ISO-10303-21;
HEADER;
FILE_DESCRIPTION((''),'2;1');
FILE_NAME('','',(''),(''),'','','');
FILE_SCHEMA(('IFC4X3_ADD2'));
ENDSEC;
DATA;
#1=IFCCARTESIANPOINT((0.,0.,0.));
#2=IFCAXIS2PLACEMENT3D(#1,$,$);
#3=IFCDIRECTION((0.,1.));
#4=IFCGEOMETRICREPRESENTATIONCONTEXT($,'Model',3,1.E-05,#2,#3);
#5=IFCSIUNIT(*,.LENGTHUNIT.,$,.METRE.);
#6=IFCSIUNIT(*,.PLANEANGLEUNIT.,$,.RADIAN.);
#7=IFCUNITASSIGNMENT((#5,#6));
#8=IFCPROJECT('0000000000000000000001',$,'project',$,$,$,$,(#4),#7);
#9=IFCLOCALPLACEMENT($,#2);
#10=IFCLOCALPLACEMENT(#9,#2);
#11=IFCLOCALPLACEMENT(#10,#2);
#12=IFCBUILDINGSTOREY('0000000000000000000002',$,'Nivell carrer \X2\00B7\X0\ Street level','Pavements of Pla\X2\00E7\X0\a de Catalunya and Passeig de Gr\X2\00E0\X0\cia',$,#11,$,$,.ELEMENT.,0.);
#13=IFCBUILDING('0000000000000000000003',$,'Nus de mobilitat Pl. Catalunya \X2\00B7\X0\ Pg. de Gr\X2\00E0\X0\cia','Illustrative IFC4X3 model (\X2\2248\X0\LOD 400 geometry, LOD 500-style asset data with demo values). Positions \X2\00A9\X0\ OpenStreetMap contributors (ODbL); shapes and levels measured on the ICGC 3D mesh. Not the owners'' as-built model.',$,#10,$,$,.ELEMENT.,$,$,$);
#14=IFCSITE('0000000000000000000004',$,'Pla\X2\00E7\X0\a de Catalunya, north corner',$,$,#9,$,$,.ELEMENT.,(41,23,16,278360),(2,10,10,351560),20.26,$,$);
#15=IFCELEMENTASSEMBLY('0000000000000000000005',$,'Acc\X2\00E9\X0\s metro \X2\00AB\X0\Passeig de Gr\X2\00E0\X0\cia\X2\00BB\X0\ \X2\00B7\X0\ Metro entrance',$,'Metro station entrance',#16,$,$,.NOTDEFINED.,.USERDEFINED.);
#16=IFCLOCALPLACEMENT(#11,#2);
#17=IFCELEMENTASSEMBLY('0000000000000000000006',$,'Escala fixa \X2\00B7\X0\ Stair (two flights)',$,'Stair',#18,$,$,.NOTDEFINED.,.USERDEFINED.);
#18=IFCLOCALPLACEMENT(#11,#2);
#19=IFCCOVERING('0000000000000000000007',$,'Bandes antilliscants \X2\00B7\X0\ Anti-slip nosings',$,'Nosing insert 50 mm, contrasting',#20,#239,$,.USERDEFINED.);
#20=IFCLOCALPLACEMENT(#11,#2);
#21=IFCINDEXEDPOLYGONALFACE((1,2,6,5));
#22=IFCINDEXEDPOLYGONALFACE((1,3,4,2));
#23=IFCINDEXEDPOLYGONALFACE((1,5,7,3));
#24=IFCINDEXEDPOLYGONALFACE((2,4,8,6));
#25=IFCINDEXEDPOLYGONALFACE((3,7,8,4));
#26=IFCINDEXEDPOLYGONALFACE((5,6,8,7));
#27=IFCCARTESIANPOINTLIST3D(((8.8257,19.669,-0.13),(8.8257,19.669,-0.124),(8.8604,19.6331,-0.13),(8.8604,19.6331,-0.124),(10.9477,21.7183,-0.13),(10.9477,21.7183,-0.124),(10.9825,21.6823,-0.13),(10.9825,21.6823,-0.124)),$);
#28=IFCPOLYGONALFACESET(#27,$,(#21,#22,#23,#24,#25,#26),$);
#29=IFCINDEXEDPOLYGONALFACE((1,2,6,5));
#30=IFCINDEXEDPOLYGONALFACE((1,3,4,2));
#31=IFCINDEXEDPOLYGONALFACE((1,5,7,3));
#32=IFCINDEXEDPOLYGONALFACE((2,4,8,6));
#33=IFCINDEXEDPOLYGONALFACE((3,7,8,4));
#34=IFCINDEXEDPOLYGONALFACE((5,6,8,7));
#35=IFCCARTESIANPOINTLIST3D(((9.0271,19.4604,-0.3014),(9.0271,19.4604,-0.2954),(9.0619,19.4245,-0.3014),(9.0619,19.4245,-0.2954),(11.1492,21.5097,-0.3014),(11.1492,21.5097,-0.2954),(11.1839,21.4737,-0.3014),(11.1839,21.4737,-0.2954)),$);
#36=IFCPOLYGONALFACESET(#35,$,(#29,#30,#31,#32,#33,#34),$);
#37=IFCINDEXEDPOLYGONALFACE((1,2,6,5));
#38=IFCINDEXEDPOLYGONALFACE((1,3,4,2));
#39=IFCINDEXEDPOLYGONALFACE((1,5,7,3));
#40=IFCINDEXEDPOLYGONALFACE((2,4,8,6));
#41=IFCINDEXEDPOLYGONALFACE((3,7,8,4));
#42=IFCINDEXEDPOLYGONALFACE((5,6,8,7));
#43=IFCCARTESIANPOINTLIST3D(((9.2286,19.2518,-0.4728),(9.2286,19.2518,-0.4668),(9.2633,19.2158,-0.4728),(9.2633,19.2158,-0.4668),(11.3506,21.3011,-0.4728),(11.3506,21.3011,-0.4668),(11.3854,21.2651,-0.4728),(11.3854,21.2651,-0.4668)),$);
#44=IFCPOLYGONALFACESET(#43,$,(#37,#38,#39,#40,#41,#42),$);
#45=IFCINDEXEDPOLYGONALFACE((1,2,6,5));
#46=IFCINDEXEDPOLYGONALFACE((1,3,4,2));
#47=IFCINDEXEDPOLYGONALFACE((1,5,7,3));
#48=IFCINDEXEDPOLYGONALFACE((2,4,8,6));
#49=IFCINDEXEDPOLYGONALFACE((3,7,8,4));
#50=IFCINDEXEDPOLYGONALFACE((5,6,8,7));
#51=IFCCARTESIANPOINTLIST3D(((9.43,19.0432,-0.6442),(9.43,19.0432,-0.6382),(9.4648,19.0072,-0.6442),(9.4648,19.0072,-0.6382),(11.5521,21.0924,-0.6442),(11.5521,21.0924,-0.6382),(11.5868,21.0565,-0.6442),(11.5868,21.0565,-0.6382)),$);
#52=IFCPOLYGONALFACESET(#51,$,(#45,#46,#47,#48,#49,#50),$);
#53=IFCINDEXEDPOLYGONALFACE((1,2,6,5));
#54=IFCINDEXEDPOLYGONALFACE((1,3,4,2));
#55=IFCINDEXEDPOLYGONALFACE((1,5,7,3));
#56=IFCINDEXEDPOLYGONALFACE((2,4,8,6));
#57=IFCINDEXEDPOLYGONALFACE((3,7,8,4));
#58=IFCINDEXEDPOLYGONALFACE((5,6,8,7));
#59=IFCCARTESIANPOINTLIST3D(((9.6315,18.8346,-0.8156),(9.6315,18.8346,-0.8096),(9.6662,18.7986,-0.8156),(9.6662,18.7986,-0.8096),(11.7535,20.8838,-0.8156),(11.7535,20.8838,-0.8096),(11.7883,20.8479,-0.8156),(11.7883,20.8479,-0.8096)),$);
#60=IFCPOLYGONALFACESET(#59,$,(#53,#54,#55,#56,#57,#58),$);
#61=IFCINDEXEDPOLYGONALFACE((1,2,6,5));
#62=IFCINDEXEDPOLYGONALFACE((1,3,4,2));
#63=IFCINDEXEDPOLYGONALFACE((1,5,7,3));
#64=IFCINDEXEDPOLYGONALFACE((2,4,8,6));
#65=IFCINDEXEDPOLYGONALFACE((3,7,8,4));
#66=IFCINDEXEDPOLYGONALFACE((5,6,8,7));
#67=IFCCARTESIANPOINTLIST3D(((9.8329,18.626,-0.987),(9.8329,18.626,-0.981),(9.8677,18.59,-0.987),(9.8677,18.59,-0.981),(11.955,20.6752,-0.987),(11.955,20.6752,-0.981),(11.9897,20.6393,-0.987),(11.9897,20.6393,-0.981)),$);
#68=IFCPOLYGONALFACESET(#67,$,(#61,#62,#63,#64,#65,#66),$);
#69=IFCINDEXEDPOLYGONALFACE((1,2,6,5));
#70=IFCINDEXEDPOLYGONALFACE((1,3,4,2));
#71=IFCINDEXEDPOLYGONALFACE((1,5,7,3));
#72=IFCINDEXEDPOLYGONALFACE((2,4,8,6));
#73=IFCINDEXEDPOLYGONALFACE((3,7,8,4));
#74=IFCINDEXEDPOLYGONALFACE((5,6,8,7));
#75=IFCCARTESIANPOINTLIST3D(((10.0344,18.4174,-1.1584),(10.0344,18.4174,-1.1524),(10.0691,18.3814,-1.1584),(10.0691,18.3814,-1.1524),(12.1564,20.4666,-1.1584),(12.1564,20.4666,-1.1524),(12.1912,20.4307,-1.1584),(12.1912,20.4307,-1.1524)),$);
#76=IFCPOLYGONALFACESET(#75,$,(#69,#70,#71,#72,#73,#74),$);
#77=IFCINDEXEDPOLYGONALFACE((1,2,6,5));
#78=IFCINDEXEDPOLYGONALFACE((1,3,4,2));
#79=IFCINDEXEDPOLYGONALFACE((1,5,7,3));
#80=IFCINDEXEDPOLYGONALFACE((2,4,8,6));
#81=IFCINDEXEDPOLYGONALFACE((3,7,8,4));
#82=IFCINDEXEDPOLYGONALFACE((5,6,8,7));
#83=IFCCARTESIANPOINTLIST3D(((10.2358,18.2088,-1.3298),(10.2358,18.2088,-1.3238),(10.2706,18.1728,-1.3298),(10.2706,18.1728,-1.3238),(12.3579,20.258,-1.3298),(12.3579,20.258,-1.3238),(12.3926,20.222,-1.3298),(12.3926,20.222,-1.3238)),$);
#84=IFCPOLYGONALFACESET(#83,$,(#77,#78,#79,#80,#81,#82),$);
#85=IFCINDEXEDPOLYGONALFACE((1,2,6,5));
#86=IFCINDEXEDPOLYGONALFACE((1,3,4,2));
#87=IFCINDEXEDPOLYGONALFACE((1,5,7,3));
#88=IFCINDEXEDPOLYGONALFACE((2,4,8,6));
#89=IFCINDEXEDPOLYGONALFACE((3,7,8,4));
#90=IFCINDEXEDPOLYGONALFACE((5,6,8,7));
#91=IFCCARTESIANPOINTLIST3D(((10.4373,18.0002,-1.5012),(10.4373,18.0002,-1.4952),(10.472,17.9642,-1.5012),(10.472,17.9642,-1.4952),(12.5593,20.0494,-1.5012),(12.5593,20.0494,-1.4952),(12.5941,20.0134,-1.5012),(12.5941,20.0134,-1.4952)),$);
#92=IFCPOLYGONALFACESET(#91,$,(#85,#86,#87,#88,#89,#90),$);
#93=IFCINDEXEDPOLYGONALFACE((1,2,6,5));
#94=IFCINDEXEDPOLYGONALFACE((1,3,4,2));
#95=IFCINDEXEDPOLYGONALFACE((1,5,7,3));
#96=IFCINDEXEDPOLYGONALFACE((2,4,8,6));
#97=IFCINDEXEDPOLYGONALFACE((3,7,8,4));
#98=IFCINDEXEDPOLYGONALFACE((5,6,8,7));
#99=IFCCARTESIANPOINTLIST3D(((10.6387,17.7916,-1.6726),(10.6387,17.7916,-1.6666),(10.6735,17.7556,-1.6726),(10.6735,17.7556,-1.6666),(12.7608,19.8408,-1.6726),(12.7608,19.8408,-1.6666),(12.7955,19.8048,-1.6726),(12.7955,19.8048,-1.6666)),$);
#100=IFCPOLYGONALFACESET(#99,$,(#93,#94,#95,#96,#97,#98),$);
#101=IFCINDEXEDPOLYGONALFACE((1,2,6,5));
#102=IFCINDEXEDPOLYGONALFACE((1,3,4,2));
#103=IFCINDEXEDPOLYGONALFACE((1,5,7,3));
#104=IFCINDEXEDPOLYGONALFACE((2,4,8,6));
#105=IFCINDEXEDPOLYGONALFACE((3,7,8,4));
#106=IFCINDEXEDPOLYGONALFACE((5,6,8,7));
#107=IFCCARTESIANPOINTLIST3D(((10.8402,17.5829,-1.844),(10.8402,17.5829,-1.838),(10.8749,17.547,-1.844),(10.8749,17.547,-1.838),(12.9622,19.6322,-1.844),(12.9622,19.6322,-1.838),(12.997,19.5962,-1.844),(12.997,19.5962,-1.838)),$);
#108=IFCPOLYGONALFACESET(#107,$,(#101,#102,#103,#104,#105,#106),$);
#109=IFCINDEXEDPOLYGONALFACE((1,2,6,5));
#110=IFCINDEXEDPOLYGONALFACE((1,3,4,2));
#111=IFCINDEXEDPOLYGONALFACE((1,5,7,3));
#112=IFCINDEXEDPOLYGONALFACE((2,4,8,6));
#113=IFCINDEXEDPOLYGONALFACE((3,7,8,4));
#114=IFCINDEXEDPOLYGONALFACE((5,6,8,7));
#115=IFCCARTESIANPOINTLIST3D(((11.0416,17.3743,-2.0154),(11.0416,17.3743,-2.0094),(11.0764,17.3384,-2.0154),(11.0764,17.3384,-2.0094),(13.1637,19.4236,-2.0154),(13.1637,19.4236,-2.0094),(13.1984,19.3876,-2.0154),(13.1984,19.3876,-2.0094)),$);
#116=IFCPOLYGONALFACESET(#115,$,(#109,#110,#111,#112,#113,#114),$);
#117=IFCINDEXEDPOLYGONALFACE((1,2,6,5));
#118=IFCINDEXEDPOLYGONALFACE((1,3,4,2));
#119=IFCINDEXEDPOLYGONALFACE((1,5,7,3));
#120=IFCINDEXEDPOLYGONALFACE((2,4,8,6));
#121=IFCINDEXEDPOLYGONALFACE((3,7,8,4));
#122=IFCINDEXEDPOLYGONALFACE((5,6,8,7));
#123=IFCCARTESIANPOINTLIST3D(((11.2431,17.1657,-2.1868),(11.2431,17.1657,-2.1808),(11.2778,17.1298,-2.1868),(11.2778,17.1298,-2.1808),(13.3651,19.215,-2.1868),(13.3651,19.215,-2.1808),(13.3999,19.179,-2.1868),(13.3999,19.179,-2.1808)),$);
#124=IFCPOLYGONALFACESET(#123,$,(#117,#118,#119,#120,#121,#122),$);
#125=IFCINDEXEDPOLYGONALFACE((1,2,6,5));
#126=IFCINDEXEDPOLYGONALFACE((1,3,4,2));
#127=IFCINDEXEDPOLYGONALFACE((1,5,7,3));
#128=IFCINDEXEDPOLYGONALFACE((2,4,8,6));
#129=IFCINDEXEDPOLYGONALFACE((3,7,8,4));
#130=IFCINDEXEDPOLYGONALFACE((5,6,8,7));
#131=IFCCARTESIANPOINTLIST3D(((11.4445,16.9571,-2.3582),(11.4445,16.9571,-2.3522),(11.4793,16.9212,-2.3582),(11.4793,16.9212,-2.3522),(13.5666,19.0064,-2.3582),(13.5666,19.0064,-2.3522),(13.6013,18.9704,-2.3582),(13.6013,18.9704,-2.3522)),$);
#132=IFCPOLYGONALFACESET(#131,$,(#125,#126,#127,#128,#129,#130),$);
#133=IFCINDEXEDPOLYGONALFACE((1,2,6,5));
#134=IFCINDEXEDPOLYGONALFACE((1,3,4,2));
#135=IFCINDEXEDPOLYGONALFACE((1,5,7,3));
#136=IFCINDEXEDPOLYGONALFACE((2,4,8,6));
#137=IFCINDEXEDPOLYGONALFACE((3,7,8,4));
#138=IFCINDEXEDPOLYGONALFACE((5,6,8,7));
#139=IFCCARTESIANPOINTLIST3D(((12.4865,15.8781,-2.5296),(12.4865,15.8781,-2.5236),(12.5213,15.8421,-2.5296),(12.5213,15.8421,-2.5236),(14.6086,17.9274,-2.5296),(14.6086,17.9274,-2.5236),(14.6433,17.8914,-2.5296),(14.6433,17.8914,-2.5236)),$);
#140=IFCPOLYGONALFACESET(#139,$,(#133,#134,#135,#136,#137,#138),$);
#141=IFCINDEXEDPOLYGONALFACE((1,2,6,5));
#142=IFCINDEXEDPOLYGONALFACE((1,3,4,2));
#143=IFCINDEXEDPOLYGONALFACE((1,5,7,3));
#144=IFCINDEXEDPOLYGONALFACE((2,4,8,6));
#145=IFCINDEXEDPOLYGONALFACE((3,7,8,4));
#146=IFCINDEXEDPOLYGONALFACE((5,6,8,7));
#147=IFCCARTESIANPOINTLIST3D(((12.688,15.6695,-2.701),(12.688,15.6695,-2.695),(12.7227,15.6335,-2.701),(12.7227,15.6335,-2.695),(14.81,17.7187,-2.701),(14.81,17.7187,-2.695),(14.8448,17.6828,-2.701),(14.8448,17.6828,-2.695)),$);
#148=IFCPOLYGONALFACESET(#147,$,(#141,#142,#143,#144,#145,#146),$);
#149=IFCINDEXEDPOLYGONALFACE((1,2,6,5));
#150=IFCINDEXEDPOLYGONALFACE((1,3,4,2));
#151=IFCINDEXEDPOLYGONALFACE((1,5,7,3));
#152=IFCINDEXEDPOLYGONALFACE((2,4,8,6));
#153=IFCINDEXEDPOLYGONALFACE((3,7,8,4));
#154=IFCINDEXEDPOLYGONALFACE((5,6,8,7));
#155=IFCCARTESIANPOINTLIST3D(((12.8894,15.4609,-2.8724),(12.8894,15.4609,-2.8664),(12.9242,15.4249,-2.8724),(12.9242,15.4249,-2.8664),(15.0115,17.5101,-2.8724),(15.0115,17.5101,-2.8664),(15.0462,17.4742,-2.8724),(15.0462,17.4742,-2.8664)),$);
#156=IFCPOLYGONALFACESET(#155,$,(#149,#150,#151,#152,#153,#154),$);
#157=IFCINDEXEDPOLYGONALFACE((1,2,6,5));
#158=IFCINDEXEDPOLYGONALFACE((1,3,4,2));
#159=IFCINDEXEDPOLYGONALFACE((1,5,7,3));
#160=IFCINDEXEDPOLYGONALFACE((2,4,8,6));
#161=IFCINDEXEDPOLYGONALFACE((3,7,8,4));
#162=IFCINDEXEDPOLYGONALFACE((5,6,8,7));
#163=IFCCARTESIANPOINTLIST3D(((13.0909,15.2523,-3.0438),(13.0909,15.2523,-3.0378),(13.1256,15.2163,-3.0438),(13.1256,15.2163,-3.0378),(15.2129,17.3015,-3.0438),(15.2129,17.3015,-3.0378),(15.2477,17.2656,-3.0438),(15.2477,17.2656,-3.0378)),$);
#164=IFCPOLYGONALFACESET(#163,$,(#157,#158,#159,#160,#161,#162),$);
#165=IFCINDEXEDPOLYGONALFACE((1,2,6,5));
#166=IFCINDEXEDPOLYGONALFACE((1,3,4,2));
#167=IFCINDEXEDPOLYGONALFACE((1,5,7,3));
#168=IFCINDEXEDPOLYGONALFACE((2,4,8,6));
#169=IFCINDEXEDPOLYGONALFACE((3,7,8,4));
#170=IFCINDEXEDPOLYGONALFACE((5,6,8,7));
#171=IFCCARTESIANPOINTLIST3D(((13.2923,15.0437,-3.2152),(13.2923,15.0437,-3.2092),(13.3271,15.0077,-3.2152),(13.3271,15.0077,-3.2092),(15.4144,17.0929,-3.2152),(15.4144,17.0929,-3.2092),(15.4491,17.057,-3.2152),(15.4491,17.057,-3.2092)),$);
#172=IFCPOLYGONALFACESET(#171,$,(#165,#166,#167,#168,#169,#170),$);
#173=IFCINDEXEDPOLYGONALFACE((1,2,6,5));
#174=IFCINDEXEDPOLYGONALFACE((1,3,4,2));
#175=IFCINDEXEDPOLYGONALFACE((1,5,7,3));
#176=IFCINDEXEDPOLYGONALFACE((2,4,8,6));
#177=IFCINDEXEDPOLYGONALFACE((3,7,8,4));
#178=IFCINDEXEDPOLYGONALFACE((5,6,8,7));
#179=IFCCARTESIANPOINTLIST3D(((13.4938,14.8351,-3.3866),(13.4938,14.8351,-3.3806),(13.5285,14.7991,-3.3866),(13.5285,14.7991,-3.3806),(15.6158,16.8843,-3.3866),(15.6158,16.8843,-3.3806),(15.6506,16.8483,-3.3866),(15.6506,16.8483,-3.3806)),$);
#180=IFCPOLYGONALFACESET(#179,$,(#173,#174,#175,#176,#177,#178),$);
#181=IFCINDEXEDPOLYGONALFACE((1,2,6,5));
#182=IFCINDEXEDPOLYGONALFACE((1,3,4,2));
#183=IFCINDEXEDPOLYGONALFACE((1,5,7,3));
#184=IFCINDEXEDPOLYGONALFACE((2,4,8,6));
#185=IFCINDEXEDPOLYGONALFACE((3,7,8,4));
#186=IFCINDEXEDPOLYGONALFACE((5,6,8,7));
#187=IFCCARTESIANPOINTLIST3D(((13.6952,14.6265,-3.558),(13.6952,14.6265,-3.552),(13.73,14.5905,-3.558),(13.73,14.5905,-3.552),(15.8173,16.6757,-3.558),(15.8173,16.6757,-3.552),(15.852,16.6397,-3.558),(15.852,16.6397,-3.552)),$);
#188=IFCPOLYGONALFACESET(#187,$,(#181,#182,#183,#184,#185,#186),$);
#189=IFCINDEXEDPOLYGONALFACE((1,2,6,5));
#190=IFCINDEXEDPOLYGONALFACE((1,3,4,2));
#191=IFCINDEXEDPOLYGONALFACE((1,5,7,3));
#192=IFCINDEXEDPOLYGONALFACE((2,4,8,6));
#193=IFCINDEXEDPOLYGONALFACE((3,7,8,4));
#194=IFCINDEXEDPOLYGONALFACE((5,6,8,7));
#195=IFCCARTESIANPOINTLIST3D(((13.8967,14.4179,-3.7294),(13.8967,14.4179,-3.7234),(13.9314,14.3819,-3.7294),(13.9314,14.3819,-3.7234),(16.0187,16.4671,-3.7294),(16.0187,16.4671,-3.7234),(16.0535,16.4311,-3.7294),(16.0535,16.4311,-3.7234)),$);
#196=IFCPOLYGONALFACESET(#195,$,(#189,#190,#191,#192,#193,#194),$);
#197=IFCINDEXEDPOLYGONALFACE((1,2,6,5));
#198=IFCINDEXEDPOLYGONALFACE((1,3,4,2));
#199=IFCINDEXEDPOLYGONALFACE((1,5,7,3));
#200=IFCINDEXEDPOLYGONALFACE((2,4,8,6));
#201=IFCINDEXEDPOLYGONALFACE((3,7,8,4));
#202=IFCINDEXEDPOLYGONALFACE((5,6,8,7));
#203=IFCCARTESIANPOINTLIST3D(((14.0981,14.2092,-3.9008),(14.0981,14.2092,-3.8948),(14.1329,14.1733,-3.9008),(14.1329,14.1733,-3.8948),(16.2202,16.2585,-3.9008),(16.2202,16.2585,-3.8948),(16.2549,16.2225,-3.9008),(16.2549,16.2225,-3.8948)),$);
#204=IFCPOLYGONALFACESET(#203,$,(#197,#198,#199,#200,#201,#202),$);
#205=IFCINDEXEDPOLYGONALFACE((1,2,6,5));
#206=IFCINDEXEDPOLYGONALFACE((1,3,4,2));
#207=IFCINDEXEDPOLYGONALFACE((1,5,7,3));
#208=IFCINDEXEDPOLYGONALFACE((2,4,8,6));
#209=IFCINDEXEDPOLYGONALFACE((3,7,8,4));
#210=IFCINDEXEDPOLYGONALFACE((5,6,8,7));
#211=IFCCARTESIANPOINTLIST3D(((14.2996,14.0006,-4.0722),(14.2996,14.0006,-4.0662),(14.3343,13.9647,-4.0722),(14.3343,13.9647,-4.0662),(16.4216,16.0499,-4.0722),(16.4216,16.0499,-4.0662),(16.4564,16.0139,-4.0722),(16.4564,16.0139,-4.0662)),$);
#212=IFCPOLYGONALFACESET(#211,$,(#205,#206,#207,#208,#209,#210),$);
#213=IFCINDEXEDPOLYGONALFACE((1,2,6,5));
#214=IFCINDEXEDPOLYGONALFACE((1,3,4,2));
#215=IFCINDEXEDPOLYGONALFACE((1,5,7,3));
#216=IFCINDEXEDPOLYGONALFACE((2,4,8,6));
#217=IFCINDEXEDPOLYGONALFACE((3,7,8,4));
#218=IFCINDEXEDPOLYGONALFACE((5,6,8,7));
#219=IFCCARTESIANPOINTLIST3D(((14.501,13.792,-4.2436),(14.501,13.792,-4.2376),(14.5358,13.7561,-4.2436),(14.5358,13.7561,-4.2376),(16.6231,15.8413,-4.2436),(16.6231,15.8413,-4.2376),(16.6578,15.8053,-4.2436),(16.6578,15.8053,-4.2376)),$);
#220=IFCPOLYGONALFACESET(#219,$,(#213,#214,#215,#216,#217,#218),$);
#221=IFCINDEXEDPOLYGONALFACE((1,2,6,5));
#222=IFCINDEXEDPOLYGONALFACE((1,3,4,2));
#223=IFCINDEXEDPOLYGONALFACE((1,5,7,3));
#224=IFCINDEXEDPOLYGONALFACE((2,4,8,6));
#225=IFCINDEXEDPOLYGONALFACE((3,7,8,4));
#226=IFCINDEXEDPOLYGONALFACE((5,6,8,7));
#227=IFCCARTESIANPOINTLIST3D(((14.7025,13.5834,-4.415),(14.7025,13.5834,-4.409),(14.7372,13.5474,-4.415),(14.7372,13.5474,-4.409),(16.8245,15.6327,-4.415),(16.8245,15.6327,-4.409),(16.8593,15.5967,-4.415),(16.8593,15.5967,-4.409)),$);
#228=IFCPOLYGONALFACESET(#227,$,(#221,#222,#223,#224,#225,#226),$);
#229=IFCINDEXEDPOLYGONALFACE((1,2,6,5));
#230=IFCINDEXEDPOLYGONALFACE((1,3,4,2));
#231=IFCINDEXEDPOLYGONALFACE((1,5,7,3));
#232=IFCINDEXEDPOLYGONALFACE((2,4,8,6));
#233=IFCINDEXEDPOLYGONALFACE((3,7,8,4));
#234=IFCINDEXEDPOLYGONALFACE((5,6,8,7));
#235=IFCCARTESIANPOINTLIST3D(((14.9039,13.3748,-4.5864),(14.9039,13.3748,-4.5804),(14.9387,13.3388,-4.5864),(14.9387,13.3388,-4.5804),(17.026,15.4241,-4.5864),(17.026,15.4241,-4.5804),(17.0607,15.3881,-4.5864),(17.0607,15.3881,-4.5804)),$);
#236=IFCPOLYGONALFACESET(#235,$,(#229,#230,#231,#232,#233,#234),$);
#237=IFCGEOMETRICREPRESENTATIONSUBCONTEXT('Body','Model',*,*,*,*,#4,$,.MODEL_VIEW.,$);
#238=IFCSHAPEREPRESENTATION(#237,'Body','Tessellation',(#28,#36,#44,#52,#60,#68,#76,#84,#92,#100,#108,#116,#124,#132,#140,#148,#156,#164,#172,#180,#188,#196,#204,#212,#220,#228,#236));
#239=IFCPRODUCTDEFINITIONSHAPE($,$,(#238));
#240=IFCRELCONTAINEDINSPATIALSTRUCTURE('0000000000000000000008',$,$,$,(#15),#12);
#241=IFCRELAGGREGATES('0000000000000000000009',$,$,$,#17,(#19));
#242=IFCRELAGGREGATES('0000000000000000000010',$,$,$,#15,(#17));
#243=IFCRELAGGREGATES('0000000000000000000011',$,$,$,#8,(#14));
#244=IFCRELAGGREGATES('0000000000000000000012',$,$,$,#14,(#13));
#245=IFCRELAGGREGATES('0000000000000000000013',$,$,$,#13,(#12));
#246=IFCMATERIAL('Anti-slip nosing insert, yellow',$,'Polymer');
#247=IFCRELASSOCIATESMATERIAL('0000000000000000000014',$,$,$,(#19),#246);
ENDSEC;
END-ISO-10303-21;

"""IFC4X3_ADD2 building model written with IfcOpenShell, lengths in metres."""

from ifc_helpers import new_model, si_unit, direction, frame, frame_2d, origin, place, context, subcontext, project, spatial, rectangle, extrude, material, element, aggregate, save


model = new_model("IFC4X3_ADD2")

# Units and contexts
model_context = context("Model", 3, precision=1e-05, world=origin(), true_north=direction((0.0, 1.0)))
body_context = subcontext(model_context, "Body", "Model", "MODEL_VIEW")
ifc_project = project(units=[si_unit("LENGTHUNIT", "METRE"), si_unit("PLANEANGLEUNIT", "RADIAN")], contexts=[model_context])

# Site, building, storey
site_placement = place(None, origin())
site = spatial("IfcSite", under=ifc_project, at=site_placement, Name="Plaça de Catalunya, north corner", CompositionType="ELEMENT", RefLatitude=(41, 23, 16, 278360), RefLongitude=(2, 10, 10, 351560), RefElevation=20.26)
building_placement = place(site_placement, origin())
building = spatial("IfcBuilding", under=site, at=building_placement, Name="Nus de mobilitat Pl. Catalunya · Pg. de Gràcia", Description="Illustrative IFC4X3 model (≈LOD 400 geometry, LOD 500-style asset data with demo values). Positions © OpenStreetMap contributors (ODbL); shapes and levels measured on the ICGC 3D mesh. Not the owners' as-built model.", CompositionType="ELEMENT")
storey_placement = place(building_placement, origin())
storey = spatial("IfcBuildingStorey", under=building, at=storey_placement, Name="Nivell carrer · Street level", Description="Pavements of Plaça de Catalunya and Passeig de Gràcia", CompositionType="ELEMENT", Elevation=0.0)

# Element assemblies, covering
assembly_1_placement = place(building_placement, origin())
assembly_1 = element("IfcElementAssembly", 1, at=assembly_1_placement, inside=storey, Name="Accés metro «Passeig de Gràcia» · Metro entrance", ObjectType="Metro station entrance", AssemblyPlace="NOTDEFINED", PredefinedType="USERDEFINED")
assembly_2_placement = place(building_placement, origin())
assembly_2 = element("IfcElementAssembly", 2, at=assembly_2_placement, Name="Escala fixa · Stair (two flights)", ObjectType="Stair", AssemblyPlace="NOTDEFINED", PredefinedType="USERDEFINED")
ifc_material_1 = material(Name="Anti-slip nosing insert, yellow", Category="Polymer")
covering_1_placement = place(building_placement, origin())
covering_1 = element("IfcCovering", 3, at=covering_1_placement, material=ifc_material_1, Name="Bandes antilliscants · Anti-slip nosings", ObjectType="Nosing insert 50 mm, contrasting", PredefinedType="USERDEFINED", context=body_context, shape_type="SweptSolid", body=[
    extrude(rectangle(XDim=0.05, YDim=2.95, at=frame_2d((0.0, 0.0), x_axis=(0.694658, -0.71934))), frame((9.9041, 20.6757, -0.13)), (0.0, 0.0, 1.0), 0.006),
    extrude(rectangle(XDim=0.05, YDim=2.95, at=frame_2d((0.0, 0.0), x_axis=(0.694658, -0.71934))), frame((10.1055, 20.4671, -0.3014)), (0.0, 0.0, 1.0), 0.006),
    extrude(rectangle(XDim=0.05, YDim=2.95, at=frame_2d((0.0, 0.0), x_axis=(0.694658, -0.71934))), frame((10.307, 20.2585, -0.4728)), (0.0, 0.0, 1.0), 0.006),
    extrude(rectangle(XDim=0.05, YDim=2.95, at=frame_2d((0.0, 0.0), x_axis=(0.694658, -0.71934))), frame((10.5084, 20.0498, -0.6442)), (0.0, 0.0, 1.0), 0.006),
    extrude(rectangle(XDim=0.05, YDim=2.95, at=frame_2d((0.0, 0.0), x_axis=(0.694658, -0.71934))), frame((10.7099, 19.8412, -0.8156)), (0.0, 0.0, 1.0), 0.006),
    extrude(rectangle(XDim=0.05, YDim=2.95, at=frame_2d((0.0, 0.0), x_axis=(0.694658, -0.71934))), frame((10.9113, 19.6326, -0.987)), (0.0, 0.0, 1.0), 0.006),
    extrude(rectangle(XDim=0.05, YDim=2.95, at=frame_2d((0.0, 0.0), x_axis=(0.694658, -0.71934))), frame((11.1128, 19.424, -1.1584)), (0.0, 0.0, 1.0), 0.006),
    extrude(rectangle(XDim=0.05, YDim=2.95, at=frame_2d((0.0, 0.0), x_axis=(0.694658, -0.71934))), frame((11.3142, 19.2154, -1.3298)), (0.0, 0.0, 1.0), 0.006),
    extrude(rectangle(XDim=0.05, YDim=2.95, at=frame_2d((0.0, 0.0), x_axis=(0.694658, -0.71934))), frame((11.5157, 19.0068, -1.5012)), (0.0, 0.0, 1.0), 0.006),
    extrude(rectangle(XDim=0.05, YDim=2.95, at=frame_2d((0.0, 0.0), x_axis=(0.694658, -0.71934))), frame((11.7171, 18.7982, -1.6726)), (0.0, 0.0, 1.0), 0.006),
    extrude(rectangle(XDim=0.05, YDim=2.95, at=frame_2d((0.0, 0.0), x_axis=(0.694658, -0.71934))), frame((11.9186, 18.5896, -1.844)), (0.0, 0.0, 1.0), 0.006),
    extrude(rectangle(XDim=0.05, YDim=2.95, at=frame_2d((0.0, 0.0), x_axis=(0.694658, -0.71934))), frame((12.12, 18.381, -2.0154)), (0.0, 0.0, 1.0), 0.006),
    extrude(rectangle(XDim=0.05, YDim=2.95, at=frame_2d((0.0, 0.0), x_axis=(0.694658, -0.71934))), frame((12.3215, 18.1724, -2.1868)), (0.0, 0.0, 1.0), 0.006),
    extrude(rectangle(XDim=0.05, YDim=2.95, at=frame_2d((0.0, 0.0), x_axis=(0.694658, -0.71934))), frame((12.5229, 17.9638, -2.3582)), (0.0, 0.0, 1.0), 0.006),
    extrude(rectangle(XDim=0.05, YDim=2.95, at=frame_2d((0.0, 0.0), x_axis=(0.694658, -0.71934))), frame((13.5649, 16.8847, -2.5296)), (0.0, 0.0, 1.0), 0.006),
    extrude(rectangle(XDim=0.05, YDim=2.95, at=frame_2d((0.0, 0.0), x_axis=(0.694658, -0.71934))), frame((13.7664, 16.6761, -2.701)), (0.0, 0.0, 1.0), 0.006),
    extrude(rectangle(XDim=0.05, YDim=2.95, at=frame_2d((0.0, 0.0), x_axis=(0.694658, -0.71934))), frame((13.9678, 16.4675, -2.8724)), (0.0, 0.0, 1.0), 0.006),
    extrude(rectangle(XDim=0.05, YDim=2.95, at=frame_2d((0.0, 0.0), x_axis=(0.694658, -0.71934))), frame((14.1693, 16.2589, -3.0438)), (0.0, 0.0, 1.0), 0.006),
    extrude(rectangle(XDim=0.05, YDim=2.95, at=frame_2d((0.0, 0.0), x_axis=(0.694658, -0.71934))), frame((14.3707, 16.0503, -3.2152)), (0.0, 0.0, 1.0), 0.006),
    extrude(rectangle(XDim=0.05, YDim=2.95, at=frame_2d((0.0, 0.0), x_axis=(0.694658, -0.71934))), frame((14.5722, 15.8417, -3.3866)), (0.0, 0.0, 1.0), 0.006),
    extrude(rectangle(XDim=0.05, YDim=2.95, at=frame_2d((0.0, 0.0), x_axis=(0.694658, -0.71934))), frame((14.7736, 15.6331, -3.558)), (0.0, 0.0, 1.0), 0.006),
    extrude(rectangle(XDim=0.05, YDim=2.95, at=frame_2d((0.0, 0.0), x_axis=(0.694658, -0.71934))), frame((14.9751, 15.4245, -3.7294)), (0.0, 0.0, 1.0), 0.006),
    extrude(rectangle(XDim=0.05, YDim=2.95, at=frame_2d((0.0, 0.0), x_axis=(0.694658, -0.71934))), frame((15.1765, 15.2159, -3.9008)), (0.0, 0.0, 1.0), 0.006),
    extrude(rectangle(XDim=0.05, YDim=2.95, at=frame_2d((0.0, 0.0), x_axis=(0.694658, -0.71934))), frame((15.378, 15.0073, -4.0722)), (0.0, 0.0, 1.0), 0.006),
    extrude(rectangle(XDim=0.05, YDim=2.95, at=frame_2d((0.0, 0.0), x_axis=(0.694658, -0.71934))), frame((15.5794, 14.7987, -4.2436)), (0.0, 0.0, 1.0), 0.006),
    extrude(rectangle(XDim=0.05, YDim=2.95, at=frame_2d((0.0, 0.0), x_axis=(0.694658, -0.71934))), frame((15.7809, 14.5901, -4.415)), (0.0, 0.0, 1.0), 0.006),
    extrude(rectangle(XDim=0.05, YDim=2.95, at=frame_2d((0.0, 0.0), x_axis=(0.694658, -0.71934))), frame((15.9823, 14.3814, -4.5864)), (0.0, 0.0, 1.0), 0.006),
])
aggregate(assembly_2, [covering_1])
aggregate(assembly_1, [assembly_2])

save(model, "model.ifc")
